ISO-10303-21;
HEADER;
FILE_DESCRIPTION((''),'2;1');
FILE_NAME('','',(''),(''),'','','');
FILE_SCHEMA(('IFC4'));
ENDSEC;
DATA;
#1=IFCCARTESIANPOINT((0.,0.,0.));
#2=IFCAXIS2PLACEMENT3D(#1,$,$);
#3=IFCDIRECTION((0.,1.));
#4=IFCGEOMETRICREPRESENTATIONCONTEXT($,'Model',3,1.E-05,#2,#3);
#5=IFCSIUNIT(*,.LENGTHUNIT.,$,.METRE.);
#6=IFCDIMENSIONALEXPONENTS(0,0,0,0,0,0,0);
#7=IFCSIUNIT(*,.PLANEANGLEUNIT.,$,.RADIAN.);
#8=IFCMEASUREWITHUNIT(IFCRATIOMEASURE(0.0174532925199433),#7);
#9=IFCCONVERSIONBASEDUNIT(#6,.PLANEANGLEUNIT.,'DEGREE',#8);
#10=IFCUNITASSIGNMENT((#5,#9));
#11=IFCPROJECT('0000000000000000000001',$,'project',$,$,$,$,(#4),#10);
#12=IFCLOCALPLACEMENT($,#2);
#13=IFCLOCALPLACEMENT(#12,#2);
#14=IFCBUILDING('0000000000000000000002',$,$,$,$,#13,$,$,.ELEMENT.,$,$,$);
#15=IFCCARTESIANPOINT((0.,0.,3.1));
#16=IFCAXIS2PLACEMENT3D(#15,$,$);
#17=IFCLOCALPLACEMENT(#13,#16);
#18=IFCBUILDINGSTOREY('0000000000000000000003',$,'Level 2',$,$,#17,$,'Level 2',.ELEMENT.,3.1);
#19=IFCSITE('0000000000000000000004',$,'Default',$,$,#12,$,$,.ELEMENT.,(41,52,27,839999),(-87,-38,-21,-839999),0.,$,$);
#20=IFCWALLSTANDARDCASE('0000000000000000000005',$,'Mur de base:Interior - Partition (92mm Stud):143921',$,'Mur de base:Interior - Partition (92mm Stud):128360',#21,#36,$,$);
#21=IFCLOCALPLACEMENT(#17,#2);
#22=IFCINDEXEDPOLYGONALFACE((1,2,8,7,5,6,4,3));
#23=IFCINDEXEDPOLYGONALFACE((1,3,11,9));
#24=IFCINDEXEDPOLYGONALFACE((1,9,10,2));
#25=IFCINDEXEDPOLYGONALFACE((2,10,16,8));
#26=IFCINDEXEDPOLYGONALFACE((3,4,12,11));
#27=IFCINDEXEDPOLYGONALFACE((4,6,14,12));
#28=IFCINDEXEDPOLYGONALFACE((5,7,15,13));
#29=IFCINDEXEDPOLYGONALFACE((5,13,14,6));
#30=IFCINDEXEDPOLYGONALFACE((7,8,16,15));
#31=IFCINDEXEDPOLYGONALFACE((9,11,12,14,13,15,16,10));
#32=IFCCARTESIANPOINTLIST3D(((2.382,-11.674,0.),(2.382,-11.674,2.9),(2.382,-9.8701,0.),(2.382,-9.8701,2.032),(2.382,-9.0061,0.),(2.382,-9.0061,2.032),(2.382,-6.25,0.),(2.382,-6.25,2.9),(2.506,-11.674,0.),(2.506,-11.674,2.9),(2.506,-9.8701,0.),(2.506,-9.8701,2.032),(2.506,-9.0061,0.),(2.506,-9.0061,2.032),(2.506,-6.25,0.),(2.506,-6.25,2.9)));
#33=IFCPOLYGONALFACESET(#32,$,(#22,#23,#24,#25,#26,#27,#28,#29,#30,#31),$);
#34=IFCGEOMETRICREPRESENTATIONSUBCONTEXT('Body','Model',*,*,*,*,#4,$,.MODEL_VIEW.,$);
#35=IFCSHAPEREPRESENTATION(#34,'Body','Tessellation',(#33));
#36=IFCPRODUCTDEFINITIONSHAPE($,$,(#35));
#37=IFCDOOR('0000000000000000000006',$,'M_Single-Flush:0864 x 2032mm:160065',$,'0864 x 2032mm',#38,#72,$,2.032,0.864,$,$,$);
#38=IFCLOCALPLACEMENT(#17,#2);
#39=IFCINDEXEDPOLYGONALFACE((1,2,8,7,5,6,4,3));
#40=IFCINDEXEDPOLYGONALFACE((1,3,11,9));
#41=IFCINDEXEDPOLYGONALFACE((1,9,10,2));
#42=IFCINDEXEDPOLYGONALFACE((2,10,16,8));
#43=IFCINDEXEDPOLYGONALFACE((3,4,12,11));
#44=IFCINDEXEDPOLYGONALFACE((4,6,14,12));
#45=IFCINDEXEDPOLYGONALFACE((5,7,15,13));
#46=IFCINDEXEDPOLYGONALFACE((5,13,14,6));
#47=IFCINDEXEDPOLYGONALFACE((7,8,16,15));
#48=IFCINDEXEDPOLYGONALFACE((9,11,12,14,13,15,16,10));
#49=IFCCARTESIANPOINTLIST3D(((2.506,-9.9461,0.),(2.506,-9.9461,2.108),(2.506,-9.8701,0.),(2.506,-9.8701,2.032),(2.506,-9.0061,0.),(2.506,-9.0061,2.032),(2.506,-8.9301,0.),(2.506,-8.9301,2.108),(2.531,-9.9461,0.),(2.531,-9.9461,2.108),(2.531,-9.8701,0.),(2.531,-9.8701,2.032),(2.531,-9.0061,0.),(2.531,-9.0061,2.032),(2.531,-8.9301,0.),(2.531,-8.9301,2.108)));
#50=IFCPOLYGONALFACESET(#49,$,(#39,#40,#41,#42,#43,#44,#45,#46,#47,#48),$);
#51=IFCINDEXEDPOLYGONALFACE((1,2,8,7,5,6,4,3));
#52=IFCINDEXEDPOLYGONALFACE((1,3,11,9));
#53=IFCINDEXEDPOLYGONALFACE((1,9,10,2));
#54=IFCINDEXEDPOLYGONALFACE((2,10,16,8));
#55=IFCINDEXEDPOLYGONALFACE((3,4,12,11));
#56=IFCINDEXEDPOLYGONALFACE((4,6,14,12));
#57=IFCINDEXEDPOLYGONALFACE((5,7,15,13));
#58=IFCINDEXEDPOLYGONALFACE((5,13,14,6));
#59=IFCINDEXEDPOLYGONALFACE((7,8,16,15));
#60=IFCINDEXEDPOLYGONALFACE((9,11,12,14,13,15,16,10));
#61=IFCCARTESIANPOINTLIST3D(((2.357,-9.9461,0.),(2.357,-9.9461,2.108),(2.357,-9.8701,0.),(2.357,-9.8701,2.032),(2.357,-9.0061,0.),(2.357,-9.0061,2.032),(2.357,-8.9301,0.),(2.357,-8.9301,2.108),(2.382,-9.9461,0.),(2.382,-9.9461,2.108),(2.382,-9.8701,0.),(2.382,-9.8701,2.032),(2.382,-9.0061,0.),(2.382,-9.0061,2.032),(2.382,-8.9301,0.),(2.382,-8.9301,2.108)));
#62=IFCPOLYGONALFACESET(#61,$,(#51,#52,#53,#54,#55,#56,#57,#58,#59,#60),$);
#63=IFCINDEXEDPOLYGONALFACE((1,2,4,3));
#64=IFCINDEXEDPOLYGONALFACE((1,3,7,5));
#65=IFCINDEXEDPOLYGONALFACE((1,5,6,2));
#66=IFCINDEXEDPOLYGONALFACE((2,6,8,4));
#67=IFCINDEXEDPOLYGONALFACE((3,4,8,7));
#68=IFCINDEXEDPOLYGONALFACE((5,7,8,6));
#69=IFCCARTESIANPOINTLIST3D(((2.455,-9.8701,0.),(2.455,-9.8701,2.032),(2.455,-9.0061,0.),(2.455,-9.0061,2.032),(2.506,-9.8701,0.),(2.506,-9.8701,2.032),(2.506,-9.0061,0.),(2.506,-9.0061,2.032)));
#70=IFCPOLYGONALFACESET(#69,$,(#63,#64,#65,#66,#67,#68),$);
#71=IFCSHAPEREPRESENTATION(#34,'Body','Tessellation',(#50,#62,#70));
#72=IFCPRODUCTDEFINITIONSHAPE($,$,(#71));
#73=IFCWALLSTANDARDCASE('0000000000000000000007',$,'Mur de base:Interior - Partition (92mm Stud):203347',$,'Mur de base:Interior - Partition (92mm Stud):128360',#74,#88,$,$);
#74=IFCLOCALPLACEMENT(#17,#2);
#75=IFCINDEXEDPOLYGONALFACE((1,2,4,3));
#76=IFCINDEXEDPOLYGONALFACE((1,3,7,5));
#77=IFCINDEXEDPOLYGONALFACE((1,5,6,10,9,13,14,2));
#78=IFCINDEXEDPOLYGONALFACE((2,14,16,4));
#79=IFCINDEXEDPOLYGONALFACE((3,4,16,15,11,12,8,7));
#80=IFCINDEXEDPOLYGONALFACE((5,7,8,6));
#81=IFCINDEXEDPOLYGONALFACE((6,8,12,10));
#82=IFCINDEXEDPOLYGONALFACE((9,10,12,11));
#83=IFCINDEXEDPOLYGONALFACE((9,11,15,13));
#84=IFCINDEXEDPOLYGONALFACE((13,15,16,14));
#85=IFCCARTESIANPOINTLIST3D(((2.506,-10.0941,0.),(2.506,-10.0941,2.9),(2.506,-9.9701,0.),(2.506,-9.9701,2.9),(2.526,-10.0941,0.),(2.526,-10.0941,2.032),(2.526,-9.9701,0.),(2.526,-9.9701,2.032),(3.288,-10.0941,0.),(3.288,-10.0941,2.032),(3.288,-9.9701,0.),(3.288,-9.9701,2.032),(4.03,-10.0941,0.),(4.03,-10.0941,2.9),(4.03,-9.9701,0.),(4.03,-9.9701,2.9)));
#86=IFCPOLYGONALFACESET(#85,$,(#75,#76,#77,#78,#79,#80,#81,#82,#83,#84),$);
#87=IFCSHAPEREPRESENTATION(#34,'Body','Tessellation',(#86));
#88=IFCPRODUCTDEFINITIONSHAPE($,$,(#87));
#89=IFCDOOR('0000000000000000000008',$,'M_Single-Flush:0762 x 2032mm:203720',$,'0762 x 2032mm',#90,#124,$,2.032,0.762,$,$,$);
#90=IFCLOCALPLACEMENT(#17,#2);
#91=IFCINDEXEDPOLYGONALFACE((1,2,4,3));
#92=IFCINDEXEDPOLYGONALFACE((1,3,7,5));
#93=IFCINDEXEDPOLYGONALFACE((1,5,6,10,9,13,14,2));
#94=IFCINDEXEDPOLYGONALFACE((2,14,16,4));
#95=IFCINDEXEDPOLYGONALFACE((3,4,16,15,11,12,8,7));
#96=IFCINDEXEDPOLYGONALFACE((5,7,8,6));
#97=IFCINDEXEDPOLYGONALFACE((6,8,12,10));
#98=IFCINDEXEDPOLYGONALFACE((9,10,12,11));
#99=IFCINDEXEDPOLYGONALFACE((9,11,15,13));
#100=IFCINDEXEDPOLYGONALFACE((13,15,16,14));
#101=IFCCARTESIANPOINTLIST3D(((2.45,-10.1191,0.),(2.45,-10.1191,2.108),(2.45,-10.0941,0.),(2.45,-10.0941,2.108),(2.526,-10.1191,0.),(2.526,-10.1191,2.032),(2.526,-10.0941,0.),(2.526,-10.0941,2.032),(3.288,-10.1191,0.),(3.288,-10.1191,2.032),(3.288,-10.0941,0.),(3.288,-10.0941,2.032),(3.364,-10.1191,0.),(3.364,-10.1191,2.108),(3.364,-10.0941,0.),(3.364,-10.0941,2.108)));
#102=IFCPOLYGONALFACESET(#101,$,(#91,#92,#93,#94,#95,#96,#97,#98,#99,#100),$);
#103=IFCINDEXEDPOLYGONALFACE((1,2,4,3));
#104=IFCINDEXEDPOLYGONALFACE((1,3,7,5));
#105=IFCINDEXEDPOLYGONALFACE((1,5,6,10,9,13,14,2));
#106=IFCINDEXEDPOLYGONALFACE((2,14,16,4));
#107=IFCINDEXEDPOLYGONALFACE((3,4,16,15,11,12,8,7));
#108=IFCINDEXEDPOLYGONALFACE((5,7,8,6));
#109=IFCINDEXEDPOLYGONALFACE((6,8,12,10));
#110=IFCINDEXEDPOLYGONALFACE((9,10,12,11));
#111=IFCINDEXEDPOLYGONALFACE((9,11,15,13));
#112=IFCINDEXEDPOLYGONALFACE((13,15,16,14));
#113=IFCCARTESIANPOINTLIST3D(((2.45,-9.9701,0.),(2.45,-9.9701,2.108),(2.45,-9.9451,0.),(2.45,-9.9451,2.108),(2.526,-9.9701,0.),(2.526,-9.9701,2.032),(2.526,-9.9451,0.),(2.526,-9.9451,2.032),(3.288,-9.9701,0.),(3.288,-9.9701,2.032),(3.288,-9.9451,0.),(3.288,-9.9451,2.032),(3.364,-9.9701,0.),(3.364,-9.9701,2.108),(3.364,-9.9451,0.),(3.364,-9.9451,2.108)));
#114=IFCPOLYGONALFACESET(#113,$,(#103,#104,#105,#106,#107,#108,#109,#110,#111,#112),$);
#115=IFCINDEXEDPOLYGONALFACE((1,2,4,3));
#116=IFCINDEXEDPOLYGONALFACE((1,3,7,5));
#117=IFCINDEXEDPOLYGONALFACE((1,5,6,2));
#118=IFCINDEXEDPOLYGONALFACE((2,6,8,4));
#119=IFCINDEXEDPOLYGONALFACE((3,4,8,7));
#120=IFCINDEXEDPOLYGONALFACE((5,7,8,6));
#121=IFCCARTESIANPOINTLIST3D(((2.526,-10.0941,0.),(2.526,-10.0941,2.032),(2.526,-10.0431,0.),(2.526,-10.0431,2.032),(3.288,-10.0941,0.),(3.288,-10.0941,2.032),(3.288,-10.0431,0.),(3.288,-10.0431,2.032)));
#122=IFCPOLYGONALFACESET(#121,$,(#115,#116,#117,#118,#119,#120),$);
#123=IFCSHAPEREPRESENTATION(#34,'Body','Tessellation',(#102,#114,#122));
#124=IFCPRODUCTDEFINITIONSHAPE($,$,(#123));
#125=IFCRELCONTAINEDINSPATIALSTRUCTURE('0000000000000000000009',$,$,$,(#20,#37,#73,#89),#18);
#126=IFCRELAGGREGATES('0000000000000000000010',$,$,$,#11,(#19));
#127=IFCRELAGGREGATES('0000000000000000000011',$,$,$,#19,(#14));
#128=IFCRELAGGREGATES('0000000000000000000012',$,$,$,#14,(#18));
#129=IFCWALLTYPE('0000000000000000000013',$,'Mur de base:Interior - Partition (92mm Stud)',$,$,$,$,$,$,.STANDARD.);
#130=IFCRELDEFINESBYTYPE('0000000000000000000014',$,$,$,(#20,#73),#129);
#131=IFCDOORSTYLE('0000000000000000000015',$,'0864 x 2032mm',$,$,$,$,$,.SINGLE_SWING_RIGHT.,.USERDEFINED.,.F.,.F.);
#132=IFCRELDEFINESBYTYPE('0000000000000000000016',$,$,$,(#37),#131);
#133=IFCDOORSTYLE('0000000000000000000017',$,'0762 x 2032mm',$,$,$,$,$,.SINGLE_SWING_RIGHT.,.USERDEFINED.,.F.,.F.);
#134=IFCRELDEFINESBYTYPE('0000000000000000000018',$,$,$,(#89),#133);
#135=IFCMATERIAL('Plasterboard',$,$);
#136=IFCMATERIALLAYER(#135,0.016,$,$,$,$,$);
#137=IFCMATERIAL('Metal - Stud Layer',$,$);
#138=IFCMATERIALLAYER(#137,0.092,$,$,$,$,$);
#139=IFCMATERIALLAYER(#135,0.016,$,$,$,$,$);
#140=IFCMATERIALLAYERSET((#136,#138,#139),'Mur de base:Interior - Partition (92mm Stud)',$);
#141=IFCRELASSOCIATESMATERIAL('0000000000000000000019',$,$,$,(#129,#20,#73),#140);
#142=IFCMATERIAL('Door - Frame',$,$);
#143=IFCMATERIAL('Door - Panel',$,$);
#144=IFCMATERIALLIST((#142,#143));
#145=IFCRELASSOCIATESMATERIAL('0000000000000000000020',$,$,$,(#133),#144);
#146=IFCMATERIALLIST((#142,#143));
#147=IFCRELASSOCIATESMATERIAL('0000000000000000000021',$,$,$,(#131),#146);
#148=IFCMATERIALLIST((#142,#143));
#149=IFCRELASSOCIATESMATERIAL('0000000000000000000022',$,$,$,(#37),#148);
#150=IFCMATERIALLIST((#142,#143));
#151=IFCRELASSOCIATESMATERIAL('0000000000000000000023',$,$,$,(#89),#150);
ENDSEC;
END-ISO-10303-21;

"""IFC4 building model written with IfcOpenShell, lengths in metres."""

from ifc_helpers import new_model, entity, si_unit, converted_unit, direction, frame, frame_2d, origin, origin_2d_with_axis, place, context, subcontext, project, spatial, polyline, rectangle, outline, extrude, source, transform, mapped, material, material_list, layer, layer_set, layer_usage, type_object, type_shapes, element, fill, save


model = new_model("IFC4")

# Units and contexts
model_context = context("Model", 3, precision=1e-05, world=origin(), true_north=direction((0.0, 1.0)))
body_context = subcontext(model_context, "Body", "Model", "MODEL_VIEW")
ifc_project = project(units=[si_unit("LENGTHUNIT", "METRE"), converted_unit("PLANEANGLEUNIT", "DEGREE", entity("IfcRatioMeasure", 0.0174532925199433), si_unit("PLANEANGLEUNIT", "RADIAN"), dimensions=[0, 0, 0, 0, 0, 0, 0])], contexts=[model_context])

# Site, building, storey
site_placement = place(None, origin())
site = spatial("IfcSite", under=ifc_project, at=site_placement, Name="Default", CompositionType="ELEMENT", RefLatitude=(41, 52, 27, 839999), RefLongitude=(-87, -38, -21, -839999), RefElevation=0.0)
building_placement = place(site_placement, origin())
building = spatial("IfcBuilding", under=site, at=building_placement, CompositionType="ELEMENT")
storey_placement = place(building_placement, frame((0.0, 0.0, 3.1)))
storey = spatial("IfcBuildingStorey", under=building, at=storey_placement, Name="Level 2", LongName="Level 2", CompositionType="ELEMENT", Elevation=3.1)

# Shared definitions
ifc_material_1 = material(Name="Metal - Stud Layer")
ifc_material_2 = material(Name="Plasterboard")

# Shared definitions
ifc_layer_1 = layer(ifc_material_2, 0.016)
ifc_layer_2 = layer(ifc_material_1, 0.092)
ifc_layer_3 = layer(ifc_material_2, 0.016)
ifc_layer_set_1 = layer_set([ifc_layer_1, ifc_layer_2, ifc_layer_3], Name="Mur de base:Interior - Partition (92mm Stud)")
wall_type_1 = type_object("IfcWallType", Name="Mur de base:Interior - Partition (92mm Stud)", PredefinedType="STANDARD", material=ifc_layer_set_1)
ifc_material_3 = material(Name="Door - Frame")
ifc_material_4 = material(Name="Door - Panel")
ifc_material_list_1 = material_list([ifc_material_3, ifc_material_4])
door_style_1 = type_object("IfcDoorStyle", Name="0762 x 2032mm", ConstructionType="USERDEFINED", OperationType="SINGLE_SWING_RIGHT", ParameterTakesPrecedence=False, Sizeable=False, material=ifc_material_list_1)
shared_shape_1 = source(origin(), body_context, "Body", "SweptSolid", [
    extrude(outline(polyline([(-0.457, -1.073), (0.457, -1.073), (0.457, 1.035), (0.381, 1.035), (0.381, -0.997), (-0.381, -0.997), (-0.381, 1.035), (-0.457, 1.035), (-0.457, -1.073)])), frame((0.381, 0.124, 1.035), z_axis=(0.0, 1.0, 0.0), x_axis=(1.0, 0.0, 0.0)), (0.0, 0.0, 1.0), 0.025),
    extrude(outline(polyline([(-1.073, -0.457), (1.035, -0.457), (1.035, -0.381), (-0.997, -0.381), (-0.997, 0.381), (1.035, 0.381), (1.035, 0.457), (-1.073, 0.457), (-1.073, -0.457)])), frame((0.381, -0.025, 1.035), z_axis=(0.0, 1.0, 0.0), x_axis=(0.0, 0.0, -1.0)), (0.0, 0.0, 1.0), 0.025),
    extrude(rectangle(XDim=0.051, YDim=0.762, at=origin_2d_with_axis()), frame((0.381, 0.0985, 0.0), z_axis=(0.0, 0.0, 1.0), x_axis=(0.0, 1.0, 0.0)), (0.0, 0.0, 1.0), 2.032),
])
type_shapes(door_style_1, [shared_shape_1])

# Walls, openings, doors
ifc_layer_usage_1 = layer_usage(ifc_layer_set_1, "AXIS2", "NEGATIVE", 0.062)
wall_1_placement = place(storey_placement, frame((2.444, -6.25, 0.0), z_axis=(0.0, 0.0, 1.0), x_axis=(0.0, -1.0, 0.0)))
wall_1 = element("IfcWallStandardCase", 1, at=wall_1_placement, inside=storey, type_object=wall_type_1, material=ifc_layer_usage_1, Name="Mur de base:Interior - Partition (92mm Stud):143921", ObjectType="Mur de base:Interior - Partition (92mm Stud):128360", context=body_context, shape_type="SweptSolid", body=[
    extrude(rectangle(XDim=5.424, YDim=0.124, at=frame_2d((2.712, 0.0), x_axis=(-1.0, 0.0))), origin(), (0.0, 0.0, 1.0), 2.9),
])
opening_1_placement = place(wall_1_placement, frame((2.7561, -0.062, 0.0)))
opening_1 = element("IfcOpeningElement", 2, at=opening_1_placement, cuts=wall_1, ObjectType="Opening", context=body_context, shape_type="SweptSolid", body=[
    extrude(rectangle(XDim=0.864, YDim=2.032, at=frame_2d((1.016, 0.432), x_axis=(0.0, 1.0))), frame((0.0, 0.0, 0.0), z_axis=(0.0, 1.0, 0.0), x_axis=(0.0, 0.0, 1.0)), (0.0, 0.0, 1.0), 0.124),
])
ifc_material_list_2 = material_list([ifc_material_3, ifc_material_4])
ifc_material_list_3 = material_list([ifc_material_3, ifc_material_4])
door_style_2 = type_object("IfcDoorStyle", Name="0864 x 2032mm", ConstructionType="USERDEFINED", OperationType="SINGLE_SWING_RIGHT", ParameterTakesPrecedence=False, Sizeable=False, material=ifc_material_list_3)
shared_shape_2 = source(origin(), body_context, "Body", "SweptSolid", [
    extrude(outline(polyline([(-0.508, -1.073), (0.508, -1.073), (0.508, 1.035), (0.432, 1.035), (0.432, -0.997), (-0.432, -0.997), (-0.432, 1.035), (-0.508, 1.035), (-0.508, -1.073)])), frame((0.432, 0.124, 1.035), z_axis=(0.0, 1.0, 0.0), x_axis=(1.0, 0.0, 0.0)), (0.0, 0.0, 1.0), 0.025),
    extrude(outline(polyline([(-1.073, -0.508), (1.035, -0.508), (1.035, -0.432), (-0.997, -0.432), (-0.997, 0.432), (1.035, 0.432), (1.035, 0.508), (-1.073, 0.508), (-1.073, -0.508)])), frame((0.432, -0.025, 1.035), z_axis=(0.0, 1.0, 0.0), x_axis=(0.0, 0.0, -1.0)), (0.0, 0.0, 1.0), 0.025),
    extrude(rectangle(XDim=0.051, YDim=0.864, at=origin_2d_with_axis()), frame((0.432, 0.0985, 0.0), z_axis=(0.0, 0.0, 1.0), x_axis=(0.0, 1.0, 0.0)), (0.0, 0.0, 1.0), 2.032),
])
type_shapes(door_style_2, [shared_shape_2])
door_1_placement = place(opening_1_placement, origin())
door_1 = element("IfcDoor", 3, at=door_1_placement, inside=storey, type_object=door_style_2, material=ifc_material_list_2, Name="M_Single-Flush:0864 x 2032mm:160065", ObjectType="0864 x 2032mm", OverallHeight=2.032, OverallWidth=0.864, context=body_context, shape_type="MappedRepresentation", body=[
    mapped(shared_shape_2, transform((0.0, 0.0, 0.0), scale=1.0)),
])
fill(opening_1, door_1)
ifc_layer_usage_2 = layer_usage(ifc_layer_set_1, "AXIS2", "NEGATIVE", 0.062)
wall_2_placement = place(storey_placement, frame((4.03, -10.0321, 0.0), z_axis=(0.0, 0.0, 1.0), x_axis=(-1.0, 0.0, 0.0)))
wall_2 = element("IfcWallStandardCase", 4, at=wall_2_placement, inside=storey, type_object=wall_type_1, material=ifc_layer_usage_2, Name="Mur de base:Interior - Partition (92mm Stud):203347", ObjectType="Mur de base:Interior - Partition (92mm Stud):128360", context=body_context, shape_type="SweptSolid", body=[
    extrude(rectangle(XDim=1.524, YDim=0.124, at=frame_2d((0.762, 0.0), x_axis=(-1.0, 0.0))), origin(), (0.0, 0.0, 1.0), 2.9),
])
opening_2_placement = place(wall_2_placement, frame((0.742, -0.062, 0.0)))
opening_2 = element("IfcOpeningElement", 5, at=opening_2_placement, cuts=wall_2, ObjectType="Opening", context=body_context, shape_type="SweptSolid", body=[
    extrude(rectangle(XDim=0.762, YDim=2.032, at=frame_2d((1.016, 0.381), x_axis=(0.0, 1.0))), frame((0.0, 0.0, 0.0), z_axis=(0.0, 1.0, 0.0), x_axis=(0.0, 0.0, 1.0)), (0.0, 0.0, 1.0), 0.124),
])
ifc_material_list_4 = material_list([ifc_material_3, ifc_material_4])
door_2_placement = place(opening_2_placement, origin())
door_2 = element("IfcDoor", 6, at=door_2_placement, inside=storey, type_object=door_style_1, material=ifc_material_list_4, Name="M_Single-Flush:0762 x 2032mm:203720", ObjectType="0762 x 2032mm", OverallHeight=2.032, OverallWidth=0.762, context=body_context, shape_type="MappedRepresentation", body=[
    mapped(shared_shape_1, transform((0.0, 0.0, 0.0), scale=1.0)),
])
fill(opening_2, door_2)

save(model, "model.ifc")
